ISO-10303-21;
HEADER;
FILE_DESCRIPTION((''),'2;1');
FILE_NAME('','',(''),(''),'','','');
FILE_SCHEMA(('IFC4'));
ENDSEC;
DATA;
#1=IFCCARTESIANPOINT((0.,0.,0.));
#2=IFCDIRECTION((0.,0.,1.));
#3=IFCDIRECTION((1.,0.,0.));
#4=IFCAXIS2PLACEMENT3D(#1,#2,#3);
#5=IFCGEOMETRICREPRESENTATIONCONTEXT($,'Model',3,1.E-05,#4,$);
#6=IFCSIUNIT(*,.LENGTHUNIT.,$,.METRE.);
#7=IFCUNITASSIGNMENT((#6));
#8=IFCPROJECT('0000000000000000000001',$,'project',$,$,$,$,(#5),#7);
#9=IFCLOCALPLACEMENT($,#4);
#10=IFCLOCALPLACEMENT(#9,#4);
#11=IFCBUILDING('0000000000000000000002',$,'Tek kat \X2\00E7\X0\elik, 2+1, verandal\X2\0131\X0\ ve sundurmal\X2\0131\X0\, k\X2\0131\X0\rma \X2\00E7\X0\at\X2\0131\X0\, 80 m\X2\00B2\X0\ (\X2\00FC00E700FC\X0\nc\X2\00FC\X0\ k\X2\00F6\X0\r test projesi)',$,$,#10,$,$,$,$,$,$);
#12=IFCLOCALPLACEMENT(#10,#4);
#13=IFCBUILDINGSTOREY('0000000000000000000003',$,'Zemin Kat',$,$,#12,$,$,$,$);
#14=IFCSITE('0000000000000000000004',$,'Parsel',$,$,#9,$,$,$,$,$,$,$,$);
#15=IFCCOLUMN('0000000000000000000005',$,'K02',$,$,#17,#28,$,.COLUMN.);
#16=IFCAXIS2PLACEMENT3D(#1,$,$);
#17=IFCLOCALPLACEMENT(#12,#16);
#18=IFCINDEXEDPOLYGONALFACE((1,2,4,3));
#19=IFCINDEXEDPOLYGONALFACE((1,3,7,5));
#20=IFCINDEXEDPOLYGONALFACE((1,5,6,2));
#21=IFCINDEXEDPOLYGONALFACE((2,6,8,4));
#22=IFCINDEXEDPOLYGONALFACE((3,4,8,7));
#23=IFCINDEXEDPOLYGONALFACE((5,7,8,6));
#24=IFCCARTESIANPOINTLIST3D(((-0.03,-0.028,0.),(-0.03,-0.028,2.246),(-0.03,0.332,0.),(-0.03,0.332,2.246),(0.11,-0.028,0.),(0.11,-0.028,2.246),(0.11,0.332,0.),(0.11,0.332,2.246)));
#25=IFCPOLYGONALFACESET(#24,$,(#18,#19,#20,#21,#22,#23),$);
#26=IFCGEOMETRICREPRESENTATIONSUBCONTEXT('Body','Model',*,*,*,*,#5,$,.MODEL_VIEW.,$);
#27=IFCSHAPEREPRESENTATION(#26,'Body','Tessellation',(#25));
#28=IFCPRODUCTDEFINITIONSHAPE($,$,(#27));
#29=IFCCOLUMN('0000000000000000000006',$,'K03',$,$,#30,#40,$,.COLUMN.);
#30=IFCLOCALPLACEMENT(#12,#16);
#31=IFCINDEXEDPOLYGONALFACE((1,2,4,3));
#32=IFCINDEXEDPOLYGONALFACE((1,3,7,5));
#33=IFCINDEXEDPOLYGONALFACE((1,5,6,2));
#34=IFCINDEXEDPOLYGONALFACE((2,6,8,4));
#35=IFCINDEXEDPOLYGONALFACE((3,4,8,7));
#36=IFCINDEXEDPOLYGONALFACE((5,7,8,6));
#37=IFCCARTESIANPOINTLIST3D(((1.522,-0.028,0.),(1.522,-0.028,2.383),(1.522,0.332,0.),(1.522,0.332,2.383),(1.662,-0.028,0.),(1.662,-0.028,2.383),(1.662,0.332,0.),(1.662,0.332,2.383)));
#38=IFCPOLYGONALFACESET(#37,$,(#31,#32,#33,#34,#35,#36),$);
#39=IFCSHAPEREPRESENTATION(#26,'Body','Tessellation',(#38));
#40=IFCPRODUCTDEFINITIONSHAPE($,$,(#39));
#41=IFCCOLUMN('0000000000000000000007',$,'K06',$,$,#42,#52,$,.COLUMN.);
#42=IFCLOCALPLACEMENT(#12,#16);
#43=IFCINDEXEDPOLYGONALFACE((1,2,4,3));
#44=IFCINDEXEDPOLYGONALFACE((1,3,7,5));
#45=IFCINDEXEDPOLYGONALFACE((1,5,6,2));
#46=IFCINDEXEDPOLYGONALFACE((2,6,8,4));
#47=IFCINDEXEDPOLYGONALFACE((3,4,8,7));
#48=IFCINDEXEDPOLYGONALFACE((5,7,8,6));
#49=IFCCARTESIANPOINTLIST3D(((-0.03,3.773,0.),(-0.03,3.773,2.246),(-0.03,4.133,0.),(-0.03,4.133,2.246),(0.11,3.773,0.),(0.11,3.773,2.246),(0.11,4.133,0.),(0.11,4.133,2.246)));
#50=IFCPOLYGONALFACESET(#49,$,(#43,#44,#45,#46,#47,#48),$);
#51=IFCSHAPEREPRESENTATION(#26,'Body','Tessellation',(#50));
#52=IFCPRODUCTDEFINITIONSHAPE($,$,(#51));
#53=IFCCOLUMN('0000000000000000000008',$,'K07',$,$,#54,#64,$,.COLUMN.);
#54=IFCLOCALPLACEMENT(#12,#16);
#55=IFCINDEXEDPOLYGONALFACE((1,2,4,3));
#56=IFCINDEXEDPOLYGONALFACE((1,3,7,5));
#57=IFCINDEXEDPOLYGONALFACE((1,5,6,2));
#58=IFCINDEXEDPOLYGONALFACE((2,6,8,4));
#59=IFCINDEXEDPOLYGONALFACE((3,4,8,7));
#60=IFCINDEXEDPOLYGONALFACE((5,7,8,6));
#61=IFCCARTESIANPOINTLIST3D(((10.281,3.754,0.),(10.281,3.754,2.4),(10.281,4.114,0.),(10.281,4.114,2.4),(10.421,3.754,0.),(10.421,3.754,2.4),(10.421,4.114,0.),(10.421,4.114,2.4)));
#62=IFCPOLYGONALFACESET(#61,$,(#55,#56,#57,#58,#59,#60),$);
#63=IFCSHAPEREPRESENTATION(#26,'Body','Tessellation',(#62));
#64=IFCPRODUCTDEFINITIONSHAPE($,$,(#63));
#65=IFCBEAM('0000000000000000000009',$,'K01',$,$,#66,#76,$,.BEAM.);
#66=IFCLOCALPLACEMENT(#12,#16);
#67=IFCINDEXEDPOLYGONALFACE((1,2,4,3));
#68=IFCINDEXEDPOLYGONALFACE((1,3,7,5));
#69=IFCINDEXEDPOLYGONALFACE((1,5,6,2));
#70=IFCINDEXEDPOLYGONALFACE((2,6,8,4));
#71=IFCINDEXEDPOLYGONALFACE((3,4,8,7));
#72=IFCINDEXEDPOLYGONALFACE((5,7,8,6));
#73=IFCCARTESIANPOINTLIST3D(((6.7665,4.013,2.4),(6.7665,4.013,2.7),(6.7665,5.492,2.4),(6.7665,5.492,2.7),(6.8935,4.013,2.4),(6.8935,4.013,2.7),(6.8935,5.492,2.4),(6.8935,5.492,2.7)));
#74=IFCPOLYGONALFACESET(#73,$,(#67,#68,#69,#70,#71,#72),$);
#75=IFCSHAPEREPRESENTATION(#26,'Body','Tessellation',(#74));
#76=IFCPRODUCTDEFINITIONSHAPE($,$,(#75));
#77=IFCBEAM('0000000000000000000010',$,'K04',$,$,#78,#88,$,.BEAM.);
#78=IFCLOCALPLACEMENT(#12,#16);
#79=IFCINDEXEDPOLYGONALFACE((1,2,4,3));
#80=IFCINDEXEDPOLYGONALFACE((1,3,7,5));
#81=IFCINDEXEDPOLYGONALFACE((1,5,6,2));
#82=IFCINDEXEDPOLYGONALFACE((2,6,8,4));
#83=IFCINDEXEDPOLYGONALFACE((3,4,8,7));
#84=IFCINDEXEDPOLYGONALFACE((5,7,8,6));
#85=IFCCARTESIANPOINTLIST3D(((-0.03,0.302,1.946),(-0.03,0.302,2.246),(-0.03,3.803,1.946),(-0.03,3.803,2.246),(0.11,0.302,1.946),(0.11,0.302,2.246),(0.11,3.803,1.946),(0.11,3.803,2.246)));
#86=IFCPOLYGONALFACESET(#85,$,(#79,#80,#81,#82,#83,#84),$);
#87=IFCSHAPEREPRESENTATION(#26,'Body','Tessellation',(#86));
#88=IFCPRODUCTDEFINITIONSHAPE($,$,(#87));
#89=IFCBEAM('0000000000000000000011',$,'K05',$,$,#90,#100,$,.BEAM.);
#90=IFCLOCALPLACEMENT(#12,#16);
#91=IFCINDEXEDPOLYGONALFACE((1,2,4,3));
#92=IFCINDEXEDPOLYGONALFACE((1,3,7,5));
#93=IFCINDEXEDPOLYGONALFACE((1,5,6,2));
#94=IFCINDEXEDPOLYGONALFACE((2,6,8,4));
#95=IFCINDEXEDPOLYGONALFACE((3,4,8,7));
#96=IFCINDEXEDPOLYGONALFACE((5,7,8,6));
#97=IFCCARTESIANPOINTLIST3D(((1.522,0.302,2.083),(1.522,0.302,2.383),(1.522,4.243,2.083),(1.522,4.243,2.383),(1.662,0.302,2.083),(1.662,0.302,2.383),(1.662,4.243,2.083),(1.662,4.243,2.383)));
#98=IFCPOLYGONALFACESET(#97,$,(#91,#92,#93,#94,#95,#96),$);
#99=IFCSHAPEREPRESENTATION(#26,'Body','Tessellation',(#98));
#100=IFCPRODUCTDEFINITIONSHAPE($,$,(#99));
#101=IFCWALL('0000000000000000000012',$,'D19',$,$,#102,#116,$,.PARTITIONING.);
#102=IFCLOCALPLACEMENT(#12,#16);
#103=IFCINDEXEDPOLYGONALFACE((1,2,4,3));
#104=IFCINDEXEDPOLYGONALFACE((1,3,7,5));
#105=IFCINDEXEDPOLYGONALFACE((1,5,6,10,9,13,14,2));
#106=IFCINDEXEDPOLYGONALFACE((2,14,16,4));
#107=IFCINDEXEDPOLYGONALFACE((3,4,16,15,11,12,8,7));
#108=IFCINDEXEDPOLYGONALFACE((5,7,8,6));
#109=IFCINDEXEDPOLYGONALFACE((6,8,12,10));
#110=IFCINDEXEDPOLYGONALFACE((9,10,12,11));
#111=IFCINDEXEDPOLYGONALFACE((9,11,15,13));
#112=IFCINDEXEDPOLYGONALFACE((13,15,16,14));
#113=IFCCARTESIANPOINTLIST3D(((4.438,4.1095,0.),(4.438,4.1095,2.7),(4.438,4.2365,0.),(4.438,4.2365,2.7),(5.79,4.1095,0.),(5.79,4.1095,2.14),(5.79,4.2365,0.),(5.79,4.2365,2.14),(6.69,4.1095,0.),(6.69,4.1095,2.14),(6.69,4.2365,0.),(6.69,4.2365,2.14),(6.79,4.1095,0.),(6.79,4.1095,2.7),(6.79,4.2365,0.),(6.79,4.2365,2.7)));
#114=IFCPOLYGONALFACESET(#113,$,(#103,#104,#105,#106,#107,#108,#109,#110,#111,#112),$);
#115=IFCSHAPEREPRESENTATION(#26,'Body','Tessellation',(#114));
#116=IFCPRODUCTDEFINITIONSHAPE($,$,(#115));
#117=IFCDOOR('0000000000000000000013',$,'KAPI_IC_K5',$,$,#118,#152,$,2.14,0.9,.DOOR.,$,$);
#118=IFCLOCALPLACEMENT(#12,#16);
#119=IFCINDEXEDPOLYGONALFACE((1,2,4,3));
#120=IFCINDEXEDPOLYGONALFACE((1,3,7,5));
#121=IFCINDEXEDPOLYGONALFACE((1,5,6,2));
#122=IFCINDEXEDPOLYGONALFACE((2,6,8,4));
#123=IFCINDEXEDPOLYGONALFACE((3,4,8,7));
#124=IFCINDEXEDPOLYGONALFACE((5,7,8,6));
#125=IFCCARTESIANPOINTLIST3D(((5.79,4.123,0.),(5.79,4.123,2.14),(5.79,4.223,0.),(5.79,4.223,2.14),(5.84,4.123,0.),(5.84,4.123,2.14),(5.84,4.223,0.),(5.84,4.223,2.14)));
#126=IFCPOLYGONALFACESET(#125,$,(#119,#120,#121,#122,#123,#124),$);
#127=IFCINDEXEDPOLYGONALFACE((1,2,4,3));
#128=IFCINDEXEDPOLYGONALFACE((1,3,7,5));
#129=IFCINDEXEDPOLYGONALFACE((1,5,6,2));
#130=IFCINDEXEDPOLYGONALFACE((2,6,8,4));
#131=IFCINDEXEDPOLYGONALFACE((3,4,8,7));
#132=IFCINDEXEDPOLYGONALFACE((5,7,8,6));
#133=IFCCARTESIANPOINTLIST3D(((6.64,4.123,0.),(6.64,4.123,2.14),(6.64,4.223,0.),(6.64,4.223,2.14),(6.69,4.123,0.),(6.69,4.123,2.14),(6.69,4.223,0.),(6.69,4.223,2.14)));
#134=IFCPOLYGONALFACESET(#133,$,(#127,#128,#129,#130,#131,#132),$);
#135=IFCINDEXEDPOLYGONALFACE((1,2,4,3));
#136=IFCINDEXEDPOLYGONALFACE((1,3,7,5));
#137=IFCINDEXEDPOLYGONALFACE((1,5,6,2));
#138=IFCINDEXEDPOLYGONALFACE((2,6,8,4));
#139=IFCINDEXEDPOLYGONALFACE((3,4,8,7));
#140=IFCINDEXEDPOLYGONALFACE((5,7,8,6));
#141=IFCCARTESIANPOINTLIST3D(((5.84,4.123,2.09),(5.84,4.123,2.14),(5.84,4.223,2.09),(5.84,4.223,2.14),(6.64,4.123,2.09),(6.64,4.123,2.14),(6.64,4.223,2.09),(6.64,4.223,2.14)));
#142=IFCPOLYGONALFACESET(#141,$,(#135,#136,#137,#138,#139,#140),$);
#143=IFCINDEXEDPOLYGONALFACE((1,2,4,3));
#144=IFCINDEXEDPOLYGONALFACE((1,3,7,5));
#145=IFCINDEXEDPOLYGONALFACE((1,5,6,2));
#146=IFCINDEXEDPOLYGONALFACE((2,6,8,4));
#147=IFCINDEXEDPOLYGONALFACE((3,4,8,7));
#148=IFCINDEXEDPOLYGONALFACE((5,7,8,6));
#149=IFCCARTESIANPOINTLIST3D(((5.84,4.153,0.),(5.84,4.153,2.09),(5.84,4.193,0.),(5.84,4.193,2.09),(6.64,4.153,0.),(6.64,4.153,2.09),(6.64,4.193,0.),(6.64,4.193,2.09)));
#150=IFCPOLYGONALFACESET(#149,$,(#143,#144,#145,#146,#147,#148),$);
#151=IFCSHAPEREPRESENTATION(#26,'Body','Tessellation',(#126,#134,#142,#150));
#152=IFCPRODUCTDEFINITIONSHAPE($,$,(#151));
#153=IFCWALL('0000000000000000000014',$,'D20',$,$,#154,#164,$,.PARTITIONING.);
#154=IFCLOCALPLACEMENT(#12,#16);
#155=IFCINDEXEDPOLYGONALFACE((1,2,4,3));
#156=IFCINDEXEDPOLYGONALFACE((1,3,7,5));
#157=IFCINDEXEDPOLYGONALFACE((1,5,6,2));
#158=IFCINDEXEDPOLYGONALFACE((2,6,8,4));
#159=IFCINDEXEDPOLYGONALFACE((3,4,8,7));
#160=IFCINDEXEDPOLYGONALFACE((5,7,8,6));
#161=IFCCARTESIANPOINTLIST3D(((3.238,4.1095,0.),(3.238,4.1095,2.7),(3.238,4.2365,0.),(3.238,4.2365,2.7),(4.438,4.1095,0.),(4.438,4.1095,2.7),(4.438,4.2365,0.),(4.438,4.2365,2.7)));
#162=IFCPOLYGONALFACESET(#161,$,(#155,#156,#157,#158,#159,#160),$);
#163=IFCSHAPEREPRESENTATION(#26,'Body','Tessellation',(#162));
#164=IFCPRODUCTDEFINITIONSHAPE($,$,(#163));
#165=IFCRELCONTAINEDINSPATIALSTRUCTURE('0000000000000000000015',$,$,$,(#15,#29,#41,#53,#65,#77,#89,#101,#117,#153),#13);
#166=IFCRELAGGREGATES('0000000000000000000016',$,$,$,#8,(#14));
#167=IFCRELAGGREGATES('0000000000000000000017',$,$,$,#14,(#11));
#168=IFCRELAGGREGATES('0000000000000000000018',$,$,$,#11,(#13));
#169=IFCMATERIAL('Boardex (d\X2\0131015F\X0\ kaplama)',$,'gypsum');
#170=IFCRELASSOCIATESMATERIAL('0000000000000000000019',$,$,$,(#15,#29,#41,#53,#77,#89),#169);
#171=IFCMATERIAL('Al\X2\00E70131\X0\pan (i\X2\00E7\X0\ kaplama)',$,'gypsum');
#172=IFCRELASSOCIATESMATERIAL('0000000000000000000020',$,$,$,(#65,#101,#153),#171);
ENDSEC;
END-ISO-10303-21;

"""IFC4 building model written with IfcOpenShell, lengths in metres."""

from ifc_helpers import new_model, si_unit, frame, origin_with_axes, place, context, subcontext, project, spatial, line, indexed_curve, outline, extrude, material, element, fill, save


model = new_model("IFC4")

# Units and contexts
model_context = context("Model", 3, precision=1e-05, world=origin_with_axes())
body_context = subcontext(model_context, "Body", "Model", "MODEL_VIEW")
ifc_project = project(units=[si_unit("LENGTHUNIT", "METRE")], contexts=[model_context])

# Site, building, storey
site_placement = place(None, origin_with_axes())
site = spatial("IfcSite", under=ifc_project, at=site_placement, Name="Parsel")
building_placement = place(site_placement, origin_with_axes())
building = spatial("IfcBuilding", under=site, at=building_placement, Name="Tek kat çelik, 2+1, verandalı ve sundurmalı, kırma çatı, 80 m² (üçüncü kör test projesi)")
storey_placement = place(building_placement, origin_with_axes())
storey = spatial("IfcBuildingStorey", under=building, at=storey_placement, Name="Zemin Kat")

# Columns
ifc_material_1 = material(Name="Boardex (dış kaplama)", Category="gypsum")
column_1_placement = place(storey_placement, origin_with_axes())
element("IfcColumn", 1, at=column_1_placement, inside=storey, material=ifc_material_1, Name="K02", PredefinedType="COLUMN", context=body_context, shape_type="SweptSolid", body=[
    extrude(outline(indexed_curve([(0.0, 0.0), (0.14, 0.0), (0.14, 0.36), (0.0, 0.36)], segments=[line(1, 2, 3, 4, 1)])), frame((-0.03, -0.028, 0.0), z_axis=(0.0, 0.0, 1.0), x_axis=(1.0, 0.0, 0.0)), (0.0, 0.0, 1.0), 2.246),
])
column_2_placement = place(storey_placement, origin_with_axes())
element("IfcColumn", 2, at=column_2_placement, inside=storey, material=ifc_material_1, Name="K03", PredefinedType="COLUMN", context=body_context, shape_type="SweptSolid", body=[
    extrude(outline(indexed_curve([(0.0, 0.0), (0.14, 0.0), (0.14, 0.36), (0.0, 0.36)], segments=[line(1, 2, 3, 4, 1)])), frame((1.522, -0.028, 0.0), z_axis=(0.0, 0.0, 1.0), x_axis=(1.0, 0.0, 0.0)), (0.0, 0.0, 1.0), 2.383),
])
column_3_placement = place(storey_placement, origin_with_axes())
element("IfcColumn", 3, at=column_3_placement, inside=storey, material=ifc_material_1, Name="K06", PredefinedType="COLUMN", context=body_context, shape_type="SweptSolid", body=[
    extrude(outline(indexed_curve([(0.0, 0.0), (0.14, 0.0), (0.14, 0.36), (0.0, 0.36)], segments=[line(1, 2, 3, 4, 1)])), frame((-0.03, 3.773, 0.0), z_axis=(0.0, 0.0, 1.0), x_axis=(1.0, 0.0, 0.0)), (0.0, 0.0, 1.0), 2.246),
])
column_4_placement = place(storey_placement, origin_with_axes())
element("IfcColumn", 4, at=column_4_placement, inside=storey, material=ifc_material_1, Name="K07", PredefinedType="COLUMN", context=body_context, shape_type="SweptSolid", body=[
    extrude(outline(indexed_curve([(0.0, 0.0), (0.14, 0.0), (0.14, 0.36), (0.0, 0.36)], segments=[line(1, 2, 3, 4, 1)])), frame((10.281, 3.754, 0.0), z_axis=(0.0, 0.0, 1.0), x_axis=(1.0, 0.0, 0.0)), (0.0, 0.0, 1.0), 2.4),
])

# Beams
ifc_material_2 = material(Name="Alçıpan (iç kaplama)", Category="gypsum")
beam_1_placement = place(storey_placement, origin_with_axes())
element("IfcBeam", 5, at=beam_1_placement, inside=storey, material=ifc_material_2, Name="K01", PredefinedType="BEAM", context=body_context, shape_type="SweptSolid", body=[
    extrude(outline(indexed_curve([(0.0, 0.0), (0.127, 0.0), (0.127, 1.479), (0.0, 1.479)], segments=[line(1, 2, 3, 4, 1)])), frame((6.7665, 4.013, 2.4), z_axis=(0.0, 0.0, 1.0), x_axis=(1.0, 0.0, 0.0)), (0.0, 0.0, 1.0), 0.3),
])
beam_2_placement = place(storey_placement, origin_with_axes())
element("IfcBeam", 6, at=beam_2_placement, inside=storey, material=ifc_material_1, Name="K04", PredefinedType="BEAM", context=body_context, shape_type="SweptSolid", body=[
    extrude(outline(indexed_curve([(0.0, 0.0), (0.14, 0.0), (0.14, 3.501), (0.0, 3.501)], segments=[line(1, 2, 3, 4, 1)])), frame((-0.03, 0.302, 1.946), z_axis=(0.0, 0.0, 1.0), x_axis=(1.0, 0.0, 0.0)), (0.0, 0.0, 1.0), 0.3),
])
beam_3_placement = place(storey_placement, origin_with_axes())
element("IfcBeam", 7, at=beam_3_placement, inside=storey, material=ifc_material_1, Name="K05", PredefinedType="BEAM", context=body_context, shape_type="SweptSolid", body=[
    extrude(outline(indexed_curve([(0.0, 0.0), (0.14, 0.0), (0.14, 3.941), (0.0, 3.941)], segments=[line(1, 2, 3, 4, 1)])), frame((1.522, 0.302, 2.083), z_axis=(0.0, 0.0, 1.0), x_axis=(1.0, 0.0, 0.0)), (0.0, 0.0, 1.0), 0.3),
])

# Wall, opening, door
wall_1_placement = place(storey_placement, origin_with_axes())
wall_1 = element("IfcWall", 8, at=wall_1_placement, inside=storey, material=ifc_material_2, Name="D19", PredefinedType="PARTITIONING", context=body_context, shape_type="SweptSolid", body=[
    extrude(outline(indexed_curve([(0.0, 0.0), (2.352, 0.0), (2.352, 0.127), (0.0, 0.127)], segments=[line(1, 2, 3, 4, 1)])), frame((4.438, 4.1095, 0.0), z_axis=(0.0, 0.0, 1.0), x_axis=(1.0, 0.0, 0.0)), (0.0, 0.0, 1.0), 2.7),
])
opening_1_placement = place(wall_1_placement, origin_with_axes())
opening_1 = element("IfcOpeningElement", 9, at=opening_1_placement, cuts=wall_1, PredefinedType="OPENING", context=body_context, shape_type="SweptSolid", body=[
    extrude(outline(indexed_curve([(0.0, 0.0), (0.9, 0.0), (0.9, 0.167), (0.0, 0.167)], segments=[line(1, 2, 3, 4, 1)])), frame((5.79, 4.0895, 0.0), z_axis=(0.0, 0.0, 1.0), x_axis=(1.0, 0.0, 0.0)), (0.0, 0.0, 1.0), 2.14),
])
door_1_placement = place(storey_placement, origin_with_axes())
door_1 = element("IfcDoor", 10, at=door_1_placement, inside=storey, Name="KAPI_IC_K5", OverallHeight=2.14, OverallWidth=0.9, PredefinedType="DOOR", context=body_context, shape_type="SweptSolid", body=[
    extrude(outline(indexed_curve([(0.0, 0.0), (0.05, 0.0), (0.05, 0.1), (0.0, 0.1)], segments=[line(1, 2, 3, 4, 1)])), frame((5.79, 4.123, 0.0), z_axis=(0.0, 0.0, 1.0), x_axis=(1.0, 0.0, 0.0)), (0.0, 0.0, 1.0), 2.14),
    extrude(outline(indexed_curve([(0.0, 0.0), (0.05, 0.0), (0.05, 0.1), (0.0, 0.1)], segments=[line(1, 2, 3, 4, 1)])), frame((6.64, 4.123, 0.0), z_axis=(0.0, 0.0, 1.0), x_axis=(1.0, 0.0, 0.0)), (0.0, 0.0, 1.0), 2.14),
    extrude(outline(indexed_curve([(0.0, 0.0), (0.8, 0.0), (0.8, 0.1), (0.0, 0.1)], segments=[line(1, 2, 3, 4, 1)])), frame((5.84, 4.123, 2.09), z_axis=(0.0, 0.0, 1.0), x_axis=(1.0, 0.0, 0.0)), (0.0, 0.0, 1.0), 0.05),
    extrude(outline(indexed_curve([(0.0, 0.0), (0.8, 0.0), (0.8, 0.04), (0.0, 0.04)], segments=[line(1, 2, 3, 4, 1)])), frame((5.84, 4.153, 0.0), z_axis=(0.0, 0.0, 1.0), x_axis=(1.0, 0.0, 0.0)), (0.0, 0.0, 1.0), 2.09),
])
fill(opening_1, door_1)

# Wall
wall_2_placement = place(storey_placement, origin_with_axes())
element("IfcWall", 11, at=wall_2_placement, inside=storey, material=ifc_material_2, Name="D20", PredefinedType="PARTITIONING", context=body_context, shape_type="SweptSolid", body=[
    extrude(outline(indexed_curve([(0.0, 0.0), (1.2, 0.0), (1.2, 0.127), (0.0, 0.127)], segments=[line(1, 2, 3, 4, 1)])), frame((3.238, 4.1095, 0.0), z_axis=(0.0, 0.0, 1.0), x_axis=(1.0, 0.0, 0.0)), (0.0, 0.0, 1.0), 2.7),
])

save(model, "model.ifc")
